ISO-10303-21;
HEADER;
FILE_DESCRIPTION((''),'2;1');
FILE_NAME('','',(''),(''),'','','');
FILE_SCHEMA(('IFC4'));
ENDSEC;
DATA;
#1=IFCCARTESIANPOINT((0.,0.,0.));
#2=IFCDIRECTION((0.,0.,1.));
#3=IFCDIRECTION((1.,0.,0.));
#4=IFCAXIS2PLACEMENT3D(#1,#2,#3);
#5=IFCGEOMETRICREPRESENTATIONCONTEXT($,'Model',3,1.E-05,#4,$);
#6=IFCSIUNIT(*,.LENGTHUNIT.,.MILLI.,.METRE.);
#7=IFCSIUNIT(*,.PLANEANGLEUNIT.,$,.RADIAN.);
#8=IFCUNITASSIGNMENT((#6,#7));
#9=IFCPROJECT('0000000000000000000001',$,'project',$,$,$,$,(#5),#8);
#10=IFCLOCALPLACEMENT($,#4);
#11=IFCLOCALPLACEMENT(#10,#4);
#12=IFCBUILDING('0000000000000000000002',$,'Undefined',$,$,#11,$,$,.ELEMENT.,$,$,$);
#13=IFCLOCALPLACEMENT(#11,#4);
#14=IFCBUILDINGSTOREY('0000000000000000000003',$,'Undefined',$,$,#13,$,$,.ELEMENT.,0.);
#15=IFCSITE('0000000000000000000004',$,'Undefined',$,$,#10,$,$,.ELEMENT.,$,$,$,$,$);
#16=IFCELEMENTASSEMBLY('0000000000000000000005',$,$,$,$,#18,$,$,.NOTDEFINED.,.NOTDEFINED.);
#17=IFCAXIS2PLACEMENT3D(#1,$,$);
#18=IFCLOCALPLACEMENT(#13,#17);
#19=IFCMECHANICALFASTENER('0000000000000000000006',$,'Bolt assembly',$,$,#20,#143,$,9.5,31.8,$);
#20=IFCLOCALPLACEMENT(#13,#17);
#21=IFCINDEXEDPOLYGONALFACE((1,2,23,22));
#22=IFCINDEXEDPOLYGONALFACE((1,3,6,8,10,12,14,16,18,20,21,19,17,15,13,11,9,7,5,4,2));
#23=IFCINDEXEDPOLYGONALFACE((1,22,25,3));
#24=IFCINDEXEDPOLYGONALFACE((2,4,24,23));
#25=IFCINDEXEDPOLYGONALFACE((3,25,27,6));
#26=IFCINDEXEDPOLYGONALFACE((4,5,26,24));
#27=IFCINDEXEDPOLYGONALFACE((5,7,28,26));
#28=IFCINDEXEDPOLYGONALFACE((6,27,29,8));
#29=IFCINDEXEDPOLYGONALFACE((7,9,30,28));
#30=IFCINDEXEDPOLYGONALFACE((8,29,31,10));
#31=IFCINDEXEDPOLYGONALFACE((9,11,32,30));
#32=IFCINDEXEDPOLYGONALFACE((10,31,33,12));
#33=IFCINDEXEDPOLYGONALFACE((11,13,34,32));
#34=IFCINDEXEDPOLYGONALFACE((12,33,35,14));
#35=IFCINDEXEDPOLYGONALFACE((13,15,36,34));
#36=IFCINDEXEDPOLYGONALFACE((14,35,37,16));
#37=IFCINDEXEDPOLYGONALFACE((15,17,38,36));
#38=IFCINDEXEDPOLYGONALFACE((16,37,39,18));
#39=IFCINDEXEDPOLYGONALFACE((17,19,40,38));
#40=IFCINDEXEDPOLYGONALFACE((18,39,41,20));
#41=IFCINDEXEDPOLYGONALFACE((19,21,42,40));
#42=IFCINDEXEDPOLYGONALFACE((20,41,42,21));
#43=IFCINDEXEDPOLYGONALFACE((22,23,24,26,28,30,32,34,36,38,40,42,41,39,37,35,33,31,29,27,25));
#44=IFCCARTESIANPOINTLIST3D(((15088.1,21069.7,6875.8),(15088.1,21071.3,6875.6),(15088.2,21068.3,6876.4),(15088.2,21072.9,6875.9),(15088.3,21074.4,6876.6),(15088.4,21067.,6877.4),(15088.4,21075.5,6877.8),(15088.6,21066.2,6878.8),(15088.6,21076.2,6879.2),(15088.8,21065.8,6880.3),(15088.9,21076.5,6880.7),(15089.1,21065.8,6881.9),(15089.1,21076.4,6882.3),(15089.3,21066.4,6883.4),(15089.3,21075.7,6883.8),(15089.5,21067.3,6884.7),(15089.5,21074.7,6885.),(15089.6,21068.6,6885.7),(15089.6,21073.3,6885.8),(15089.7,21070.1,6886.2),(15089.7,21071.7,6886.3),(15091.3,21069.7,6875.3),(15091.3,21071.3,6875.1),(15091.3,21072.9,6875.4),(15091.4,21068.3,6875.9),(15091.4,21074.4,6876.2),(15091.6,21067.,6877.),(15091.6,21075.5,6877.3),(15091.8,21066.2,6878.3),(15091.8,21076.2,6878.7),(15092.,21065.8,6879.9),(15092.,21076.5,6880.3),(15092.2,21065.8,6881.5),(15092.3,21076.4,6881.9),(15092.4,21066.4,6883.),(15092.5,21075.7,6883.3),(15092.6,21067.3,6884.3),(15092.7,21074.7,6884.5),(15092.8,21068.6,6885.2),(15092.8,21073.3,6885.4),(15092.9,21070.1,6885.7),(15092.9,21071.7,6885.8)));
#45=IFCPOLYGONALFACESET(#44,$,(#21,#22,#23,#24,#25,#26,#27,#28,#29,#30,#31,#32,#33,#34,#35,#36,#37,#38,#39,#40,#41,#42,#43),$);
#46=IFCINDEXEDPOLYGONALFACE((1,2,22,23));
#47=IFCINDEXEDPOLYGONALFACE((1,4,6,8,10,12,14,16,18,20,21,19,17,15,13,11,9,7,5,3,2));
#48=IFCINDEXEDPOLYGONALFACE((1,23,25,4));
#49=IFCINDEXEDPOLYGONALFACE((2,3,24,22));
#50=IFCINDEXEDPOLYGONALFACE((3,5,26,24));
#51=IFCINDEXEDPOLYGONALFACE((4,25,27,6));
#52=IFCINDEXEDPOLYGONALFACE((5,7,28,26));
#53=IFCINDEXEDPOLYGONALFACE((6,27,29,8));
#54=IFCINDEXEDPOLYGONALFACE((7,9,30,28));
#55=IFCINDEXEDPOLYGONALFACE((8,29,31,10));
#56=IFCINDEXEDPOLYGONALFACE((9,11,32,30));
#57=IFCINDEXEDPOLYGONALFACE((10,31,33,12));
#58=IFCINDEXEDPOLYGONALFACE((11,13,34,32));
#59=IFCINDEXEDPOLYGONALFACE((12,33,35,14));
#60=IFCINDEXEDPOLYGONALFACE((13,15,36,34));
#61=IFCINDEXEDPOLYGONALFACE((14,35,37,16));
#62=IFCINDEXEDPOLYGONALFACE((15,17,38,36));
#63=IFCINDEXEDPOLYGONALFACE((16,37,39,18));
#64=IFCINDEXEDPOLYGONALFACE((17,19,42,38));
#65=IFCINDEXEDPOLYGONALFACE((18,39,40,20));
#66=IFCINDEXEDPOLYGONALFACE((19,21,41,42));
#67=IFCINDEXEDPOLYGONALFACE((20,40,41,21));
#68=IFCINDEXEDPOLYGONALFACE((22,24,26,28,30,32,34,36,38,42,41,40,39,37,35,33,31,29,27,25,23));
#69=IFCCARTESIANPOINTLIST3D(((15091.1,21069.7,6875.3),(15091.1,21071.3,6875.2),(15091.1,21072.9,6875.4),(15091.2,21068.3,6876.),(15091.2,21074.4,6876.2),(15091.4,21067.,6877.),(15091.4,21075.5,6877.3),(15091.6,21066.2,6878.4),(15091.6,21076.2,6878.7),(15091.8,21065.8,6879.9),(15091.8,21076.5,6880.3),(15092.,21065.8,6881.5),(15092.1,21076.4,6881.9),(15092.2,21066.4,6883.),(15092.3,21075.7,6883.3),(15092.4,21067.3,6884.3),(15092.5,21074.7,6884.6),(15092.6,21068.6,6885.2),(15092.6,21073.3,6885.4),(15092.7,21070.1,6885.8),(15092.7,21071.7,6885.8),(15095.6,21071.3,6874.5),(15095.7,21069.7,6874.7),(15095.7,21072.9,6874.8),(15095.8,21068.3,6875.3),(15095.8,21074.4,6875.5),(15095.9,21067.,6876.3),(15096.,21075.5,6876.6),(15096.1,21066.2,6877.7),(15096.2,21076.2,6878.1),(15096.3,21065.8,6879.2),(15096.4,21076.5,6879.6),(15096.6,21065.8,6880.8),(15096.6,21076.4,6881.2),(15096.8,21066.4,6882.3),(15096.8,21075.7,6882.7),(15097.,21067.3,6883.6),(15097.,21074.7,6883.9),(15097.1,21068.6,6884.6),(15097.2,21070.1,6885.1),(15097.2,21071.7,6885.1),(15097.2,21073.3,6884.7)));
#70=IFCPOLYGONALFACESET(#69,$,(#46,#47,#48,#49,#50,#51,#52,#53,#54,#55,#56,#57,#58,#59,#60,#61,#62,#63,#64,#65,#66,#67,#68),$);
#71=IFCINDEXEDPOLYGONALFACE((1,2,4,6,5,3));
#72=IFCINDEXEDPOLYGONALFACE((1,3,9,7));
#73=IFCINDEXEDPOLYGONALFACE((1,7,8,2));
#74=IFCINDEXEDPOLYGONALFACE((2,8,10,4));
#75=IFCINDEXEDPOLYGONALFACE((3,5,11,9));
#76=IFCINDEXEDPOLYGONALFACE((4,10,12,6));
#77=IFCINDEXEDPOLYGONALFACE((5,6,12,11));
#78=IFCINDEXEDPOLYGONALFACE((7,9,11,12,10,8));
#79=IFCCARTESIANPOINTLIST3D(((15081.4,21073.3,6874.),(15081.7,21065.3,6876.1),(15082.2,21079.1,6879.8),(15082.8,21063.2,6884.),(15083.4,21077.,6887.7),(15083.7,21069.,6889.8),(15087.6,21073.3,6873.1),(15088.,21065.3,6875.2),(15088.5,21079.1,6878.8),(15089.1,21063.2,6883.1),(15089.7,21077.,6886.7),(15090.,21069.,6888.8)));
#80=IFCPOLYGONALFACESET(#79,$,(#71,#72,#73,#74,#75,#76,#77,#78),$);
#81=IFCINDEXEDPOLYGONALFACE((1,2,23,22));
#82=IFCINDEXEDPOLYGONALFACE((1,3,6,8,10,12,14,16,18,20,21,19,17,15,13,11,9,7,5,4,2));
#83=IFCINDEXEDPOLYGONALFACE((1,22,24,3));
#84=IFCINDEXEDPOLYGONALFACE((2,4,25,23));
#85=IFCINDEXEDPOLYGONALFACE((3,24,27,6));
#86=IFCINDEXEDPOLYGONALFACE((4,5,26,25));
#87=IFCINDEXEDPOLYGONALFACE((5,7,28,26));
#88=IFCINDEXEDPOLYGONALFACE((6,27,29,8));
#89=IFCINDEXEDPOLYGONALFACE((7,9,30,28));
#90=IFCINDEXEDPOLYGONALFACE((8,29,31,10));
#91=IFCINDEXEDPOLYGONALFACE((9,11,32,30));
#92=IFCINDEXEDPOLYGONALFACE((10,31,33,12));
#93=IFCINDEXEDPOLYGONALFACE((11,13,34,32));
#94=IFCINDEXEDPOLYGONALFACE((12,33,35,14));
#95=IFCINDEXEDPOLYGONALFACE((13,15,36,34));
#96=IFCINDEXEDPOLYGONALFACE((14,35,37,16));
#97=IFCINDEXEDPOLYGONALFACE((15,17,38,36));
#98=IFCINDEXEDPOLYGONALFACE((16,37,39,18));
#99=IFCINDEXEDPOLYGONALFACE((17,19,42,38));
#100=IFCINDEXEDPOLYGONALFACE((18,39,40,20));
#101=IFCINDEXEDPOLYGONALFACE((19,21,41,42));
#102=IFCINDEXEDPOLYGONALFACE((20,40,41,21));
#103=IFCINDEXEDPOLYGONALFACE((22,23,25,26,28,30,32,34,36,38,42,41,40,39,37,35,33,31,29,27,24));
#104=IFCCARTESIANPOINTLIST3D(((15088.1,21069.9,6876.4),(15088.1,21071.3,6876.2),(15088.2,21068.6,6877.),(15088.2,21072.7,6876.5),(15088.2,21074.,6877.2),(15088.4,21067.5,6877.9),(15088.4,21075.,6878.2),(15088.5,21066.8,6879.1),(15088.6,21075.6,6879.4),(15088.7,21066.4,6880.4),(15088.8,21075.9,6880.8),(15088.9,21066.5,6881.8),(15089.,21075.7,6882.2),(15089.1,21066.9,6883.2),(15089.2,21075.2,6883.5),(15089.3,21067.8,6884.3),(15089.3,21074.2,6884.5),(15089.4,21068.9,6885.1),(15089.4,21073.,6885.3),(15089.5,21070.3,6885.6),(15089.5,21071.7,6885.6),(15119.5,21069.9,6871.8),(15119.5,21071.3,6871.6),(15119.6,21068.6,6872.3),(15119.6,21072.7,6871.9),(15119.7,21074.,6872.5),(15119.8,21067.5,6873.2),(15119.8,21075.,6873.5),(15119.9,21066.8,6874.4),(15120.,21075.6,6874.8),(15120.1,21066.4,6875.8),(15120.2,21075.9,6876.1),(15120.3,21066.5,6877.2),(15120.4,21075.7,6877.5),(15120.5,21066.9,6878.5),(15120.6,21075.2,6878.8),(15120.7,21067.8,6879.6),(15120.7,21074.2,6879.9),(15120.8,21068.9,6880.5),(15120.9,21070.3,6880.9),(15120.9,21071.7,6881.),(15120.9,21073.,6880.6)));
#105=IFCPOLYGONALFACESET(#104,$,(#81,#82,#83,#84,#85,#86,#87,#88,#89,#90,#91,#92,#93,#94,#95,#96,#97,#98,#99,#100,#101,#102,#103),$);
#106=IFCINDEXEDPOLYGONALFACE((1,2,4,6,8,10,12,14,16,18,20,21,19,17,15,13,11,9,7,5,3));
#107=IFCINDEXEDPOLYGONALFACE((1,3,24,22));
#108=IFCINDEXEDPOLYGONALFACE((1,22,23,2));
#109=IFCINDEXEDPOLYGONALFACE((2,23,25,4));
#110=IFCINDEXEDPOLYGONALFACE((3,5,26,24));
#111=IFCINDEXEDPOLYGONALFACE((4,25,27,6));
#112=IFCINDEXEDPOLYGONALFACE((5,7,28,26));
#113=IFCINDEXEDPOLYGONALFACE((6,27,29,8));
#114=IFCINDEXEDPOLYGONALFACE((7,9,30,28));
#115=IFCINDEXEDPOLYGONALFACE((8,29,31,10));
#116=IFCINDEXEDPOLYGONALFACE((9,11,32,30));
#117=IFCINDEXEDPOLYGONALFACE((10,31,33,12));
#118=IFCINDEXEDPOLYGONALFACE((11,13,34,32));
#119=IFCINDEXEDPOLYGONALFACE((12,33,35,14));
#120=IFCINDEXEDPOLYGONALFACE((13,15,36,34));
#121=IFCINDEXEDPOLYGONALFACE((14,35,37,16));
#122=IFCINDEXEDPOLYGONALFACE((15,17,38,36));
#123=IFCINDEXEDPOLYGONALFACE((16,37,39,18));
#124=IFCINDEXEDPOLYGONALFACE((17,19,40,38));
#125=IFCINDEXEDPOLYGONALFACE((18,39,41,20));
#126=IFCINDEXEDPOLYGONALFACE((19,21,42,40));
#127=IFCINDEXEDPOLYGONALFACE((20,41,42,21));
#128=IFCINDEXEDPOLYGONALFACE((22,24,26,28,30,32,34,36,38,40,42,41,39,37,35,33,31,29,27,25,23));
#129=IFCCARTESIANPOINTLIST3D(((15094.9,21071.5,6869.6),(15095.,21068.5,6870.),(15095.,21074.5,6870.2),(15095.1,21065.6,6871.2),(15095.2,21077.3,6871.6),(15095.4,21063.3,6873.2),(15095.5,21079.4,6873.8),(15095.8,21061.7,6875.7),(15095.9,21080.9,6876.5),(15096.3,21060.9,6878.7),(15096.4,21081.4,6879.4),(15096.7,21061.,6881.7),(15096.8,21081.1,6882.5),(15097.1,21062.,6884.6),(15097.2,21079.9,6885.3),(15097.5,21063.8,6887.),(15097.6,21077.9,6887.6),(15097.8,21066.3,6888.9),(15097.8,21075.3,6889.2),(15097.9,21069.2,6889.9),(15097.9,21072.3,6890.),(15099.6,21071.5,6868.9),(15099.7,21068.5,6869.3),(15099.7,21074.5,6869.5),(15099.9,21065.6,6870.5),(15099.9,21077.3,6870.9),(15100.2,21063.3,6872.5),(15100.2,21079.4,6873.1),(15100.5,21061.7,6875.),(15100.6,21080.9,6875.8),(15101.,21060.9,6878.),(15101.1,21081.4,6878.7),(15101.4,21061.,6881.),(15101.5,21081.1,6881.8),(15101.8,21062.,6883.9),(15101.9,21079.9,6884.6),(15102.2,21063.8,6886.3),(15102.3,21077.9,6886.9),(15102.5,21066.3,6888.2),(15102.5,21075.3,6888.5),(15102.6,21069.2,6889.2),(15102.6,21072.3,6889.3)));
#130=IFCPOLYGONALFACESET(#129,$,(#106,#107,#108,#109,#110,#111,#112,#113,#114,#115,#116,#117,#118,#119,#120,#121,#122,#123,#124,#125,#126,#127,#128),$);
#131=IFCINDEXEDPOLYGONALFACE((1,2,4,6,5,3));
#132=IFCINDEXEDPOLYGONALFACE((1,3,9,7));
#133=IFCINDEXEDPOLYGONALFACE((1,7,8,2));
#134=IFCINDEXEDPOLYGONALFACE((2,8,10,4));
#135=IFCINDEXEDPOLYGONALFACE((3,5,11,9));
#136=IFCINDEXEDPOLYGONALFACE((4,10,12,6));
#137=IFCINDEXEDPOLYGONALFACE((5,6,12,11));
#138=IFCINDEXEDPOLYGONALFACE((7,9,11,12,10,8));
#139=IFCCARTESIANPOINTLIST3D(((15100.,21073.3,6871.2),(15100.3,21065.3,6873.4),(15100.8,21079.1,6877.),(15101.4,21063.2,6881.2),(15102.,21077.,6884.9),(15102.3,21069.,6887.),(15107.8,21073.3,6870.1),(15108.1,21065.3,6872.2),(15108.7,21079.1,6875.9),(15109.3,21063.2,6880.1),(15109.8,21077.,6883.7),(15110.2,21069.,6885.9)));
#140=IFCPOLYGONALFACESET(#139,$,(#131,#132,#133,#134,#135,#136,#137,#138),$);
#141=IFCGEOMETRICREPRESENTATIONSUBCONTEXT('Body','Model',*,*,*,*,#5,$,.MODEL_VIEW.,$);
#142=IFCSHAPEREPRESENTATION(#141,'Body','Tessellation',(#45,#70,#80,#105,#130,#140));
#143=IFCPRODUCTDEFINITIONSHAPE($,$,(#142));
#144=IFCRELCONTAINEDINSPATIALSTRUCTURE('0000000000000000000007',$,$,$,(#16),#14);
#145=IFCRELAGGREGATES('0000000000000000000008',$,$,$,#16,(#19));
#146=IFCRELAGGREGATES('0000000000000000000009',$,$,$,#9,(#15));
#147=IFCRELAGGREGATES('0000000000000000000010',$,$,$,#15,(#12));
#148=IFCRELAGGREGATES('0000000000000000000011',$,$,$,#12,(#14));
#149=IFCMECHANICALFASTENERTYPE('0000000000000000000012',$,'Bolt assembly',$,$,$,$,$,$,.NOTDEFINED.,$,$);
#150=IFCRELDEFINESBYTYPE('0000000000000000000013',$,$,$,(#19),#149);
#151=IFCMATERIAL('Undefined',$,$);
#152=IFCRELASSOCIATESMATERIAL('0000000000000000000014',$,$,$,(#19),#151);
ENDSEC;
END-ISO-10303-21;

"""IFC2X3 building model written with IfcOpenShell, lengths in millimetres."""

from ifc_helpers import new_model, si_unit, frame, origin_with_axes, origin_2d_with_axis, place, context, subcontext, project, spatial, polyline, circle, outline, extrude, source, transform, mapped, material, type_object, element, aggregate, save


model = new_model("IFC2X3")

# Units and contexts
model_context = context("Model", 3, precision=1e-05, world=origin_with_axes())
body_context = subcontext(model_context, "Body", "Model", "MODEL_VIEW")
ifc_project = project(units=[si_unit("LENGTHUNIT", "METRE", prefix="MILLI"), si_unit("PLANEANGLEUNIT", "RADIAN")], contexts=[model_context])

# Site, building, storey
site_placement = place(None, origin_with_axes())
site = spatial("IfcSite", under=ifc_project, at=site_placement, Name="Undefined", CompositionType="ELEMENT")
building_placement = place(site_placement, origin_with_axes())
building = spatial("IfcBuilding", under=site, at=building_placement, Name="Undefined", CompositionType="ELEMENT")
storey_placement = place(building_placement, origin_with_axes())
storey = spatial("IfcBuildingStorey", under=building, at=storey_placement, Name="Undefined", CompositionType="ELEMENT", Elevation=0.0)

# Element assembly
assembly_1_placement = place(storey_placement, origin_with_axes())
assembly_1 = element("IfcElementAssembly", 1, at=assembly_1_placement, inside=storey, AssemblyPlace="NOTDEFINED", PredefinedType="NOTDEFINED")

# Shared definitions
ifc_material_1 = material(Name="Undefined")
mechanical_fastener_type = type_object("IfcMechanicalFastenerType", Name="Bolt assembly")

# Mechanical fastener
shared_shape_1 = source(origin_with_axes(), body_context, "Body", "SweptSolid", [
    extrude(circle(Radius=5.4, at=origin_2d_with_axis()), frame((0.0, -3.1, 0.0), z_axis=(0.0, 1.0, 0.0), x_axis=(1.0, 0.0, 0.0)), (0.0, 0.0, 1.0), 3.2),
    extrude(circle(Radius=5.4, at=origin_2d_with_axis()), frame((0.0, -0.1, 0.0), z_axis=(0.0, 1.0, 0.0), x_axis=(1.0, 0.0, 0.0)), (0.0, 0.0, 1.0), 4.6),
    extrude(outline(polyline([(7.1, -4.1), (7.1, 4.1), (0.0, 8.2), (-7.1, 4.1), (-7.1, -4.1), (0.0, -8.2), (7.1, -4.1)])), frame((0.0, -9.6, 0.0), z_axis=(0.0, 1.0, 0.0), x_axis=(1.0, 0.0, 0.0)), (0.0, 0.0, 1.0), 6.3),
    extrude(circle(Radius=4.8, at=origin_2d_with_axis()), frame((0.0, -3.2, 0.0), z_axis=(0.0, 1.0, 0.0), x_axis=(1.0, 0.0, 0.0)), (0.0, 0.0, 1.0), 31.8),
    extrude(circle(Radius=10.3, at=origin_2d_with_axis()), frame((0.0, 4.5, 0.0), z_axis=(0.0, 1.0, 0.0), x_axis=(1.0, 0.0, 0.0)), (0.0, 0.0, 1.0), 4.8),
    extrude(outline(polyline([(7.1, -4.1), (7.1, 4.1), (0.0, 8.2), (-7.1, 4.1), (-7.1, -4.1), (0.0, -8.2), (7.1, -4.1)])), frame((0.0, 9.3, 0.0), z_axis=(0.0, 1.0, 0.0), x_axis=(1.0, 0.0, 0.0)), (0.0, 0.0, 1.0), 7.9),
])
mechanical_fastener_1_placement = place(assembly_1_placement, frame((15092.0, 21071.1, 6880.5), z_axis=(0.10338, 0.707107, 0.699509), x_axis=(0.10338, -0.707107, 0.699509)))
mechanical_fastener_1 = element("IfcMechanicalFastener", 2, at=mechanical_fastener_1_placement, type_object=mechanical_fastener_type, material=ifc_material_1, Name="Bolt assembly", NominalDiameter=9.5, NominalLength=31.8, context=body_context, shape_type="MappedRepresentation", body=[
    mapped(shared_shape_1, transform((0.0, 0.0, 0.0))),
])
aggregate(assembly_1, [mechanical_fastener_1])

save(model, "model.ifc")
